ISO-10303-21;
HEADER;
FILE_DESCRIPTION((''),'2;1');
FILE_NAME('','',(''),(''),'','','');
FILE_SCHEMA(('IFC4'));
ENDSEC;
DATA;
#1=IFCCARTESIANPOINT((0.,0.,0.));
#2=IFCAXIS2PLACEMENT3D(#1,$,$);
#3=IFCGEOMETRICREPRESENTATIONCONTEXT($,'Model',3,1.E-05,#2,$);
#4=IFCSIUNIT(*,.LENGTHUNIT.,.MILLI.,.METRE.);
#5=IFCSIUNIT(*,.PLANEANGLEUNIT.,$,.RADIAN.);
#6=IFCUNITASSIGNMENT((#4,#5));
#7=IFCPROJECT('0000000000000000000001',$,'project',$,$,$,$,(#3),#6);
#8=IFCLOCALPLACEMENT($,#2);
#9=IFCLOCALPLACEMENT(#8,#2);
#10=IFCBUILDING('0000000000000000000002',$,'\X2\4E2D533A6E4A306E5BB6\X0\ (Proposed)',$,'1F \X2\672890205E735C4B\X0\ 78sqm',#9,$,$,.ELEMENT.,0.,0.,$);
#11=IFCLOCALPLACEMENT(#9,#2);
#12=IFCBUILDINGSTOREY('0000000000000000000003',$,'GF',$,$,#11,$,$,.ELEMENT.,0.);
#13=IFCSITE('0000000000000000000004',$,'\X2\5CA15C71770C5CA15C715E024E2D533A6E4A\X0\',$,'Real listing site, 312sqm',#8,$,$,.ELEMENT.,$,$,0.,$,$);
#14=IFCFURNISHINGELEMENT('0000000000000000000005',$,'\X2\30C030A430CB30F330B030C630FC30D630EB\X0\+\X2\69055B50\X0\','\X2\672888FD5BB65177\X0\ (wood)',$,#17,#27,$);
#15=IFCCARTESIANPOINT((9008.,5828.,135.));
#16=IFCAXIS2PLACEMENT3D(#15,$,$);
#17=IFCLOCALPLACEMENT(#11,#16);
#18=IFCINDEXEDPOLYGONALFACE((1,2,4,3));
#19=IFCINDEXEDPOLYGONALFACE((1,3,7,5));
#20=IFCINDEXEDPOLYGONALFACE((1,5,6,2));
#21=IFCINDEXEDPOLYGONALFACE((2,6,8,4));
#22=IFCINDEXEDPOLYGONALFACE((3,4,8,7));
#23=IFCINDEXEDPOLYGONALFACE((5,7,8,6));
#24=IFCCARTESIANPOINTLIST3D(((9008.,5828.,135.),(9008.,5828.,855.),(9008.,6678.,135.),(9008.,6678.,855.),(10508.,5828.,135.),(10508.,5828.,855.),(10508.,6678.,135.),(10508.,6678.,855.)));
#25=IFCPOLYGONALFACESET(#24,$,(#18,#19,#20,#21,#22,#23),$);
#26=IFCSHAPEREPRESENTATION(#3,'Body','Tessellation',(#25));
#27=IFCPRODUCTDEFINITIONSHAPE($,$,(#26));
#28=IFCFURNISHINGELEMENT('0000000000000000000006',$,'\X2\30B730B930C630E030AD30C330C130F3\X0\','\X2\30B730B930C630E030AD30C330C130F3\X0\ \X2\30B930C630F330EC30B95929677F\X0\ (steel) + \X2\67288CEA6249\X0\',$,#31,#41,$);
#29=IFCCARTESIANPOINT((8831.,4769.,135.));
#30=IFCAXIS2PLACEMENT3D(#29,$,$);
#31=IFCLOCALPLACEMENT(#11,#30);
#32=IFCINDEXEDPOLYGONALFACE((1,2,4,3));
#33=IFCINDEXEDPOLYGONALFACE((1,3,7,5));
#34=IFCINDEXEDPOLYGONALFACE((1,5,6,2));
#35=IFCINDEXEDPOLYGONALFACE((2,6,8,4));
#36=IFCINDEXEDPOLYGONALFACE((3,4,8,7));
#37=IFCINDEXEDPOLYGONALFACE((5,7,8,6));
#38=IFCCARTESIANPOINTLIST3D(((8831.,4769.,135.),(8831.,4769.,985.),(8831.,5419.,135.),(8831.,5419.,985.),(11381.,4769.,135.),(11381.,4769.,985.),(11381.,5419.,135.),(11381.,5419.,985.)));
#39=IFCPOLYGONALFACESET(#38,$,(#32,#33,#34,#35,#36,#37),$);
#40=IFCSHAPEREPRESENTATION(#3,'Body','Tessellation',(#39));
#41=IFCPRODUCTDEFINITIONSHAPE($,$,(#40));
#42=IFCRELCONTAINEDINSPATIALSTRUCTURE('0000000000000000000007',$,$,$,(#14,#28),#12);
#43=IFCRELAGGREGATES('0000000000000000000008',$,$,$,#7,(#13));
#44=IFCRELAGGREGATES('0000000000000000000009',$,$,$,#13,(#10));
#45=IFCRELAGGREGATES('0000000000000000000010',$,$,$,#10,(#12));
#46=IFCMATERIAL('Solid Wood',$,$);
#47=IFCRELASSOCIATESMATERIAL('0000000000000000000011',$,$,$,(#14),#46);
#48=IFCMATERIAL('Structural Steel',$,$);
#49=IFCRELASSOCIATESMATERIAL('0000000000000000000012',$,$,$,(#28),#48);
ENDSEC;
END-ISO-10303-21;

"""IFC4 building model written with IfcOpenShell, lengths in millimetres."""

from ifc_helpers import new_model, si_unit, frame, frame_2d, origin, place, context, project, spatial, rectangle, extrude, material, element, save


model = new_model("IFC4")

# Units and contexts
model_context = context("Model", 3, precision=1e-05, world=origin())
ifc_project = project(units=[si_unit("LENGTHUNIT", "METRE", prefix="MILLI"), si_unit("PLANEANGLEUNIT", "RADIAN")], contexts=[model_context])

# Site, building, storey
site_placement = place(None, origin())
site = spatial("IfcSite", under=ifc_project, at=site_placement, Name="岡山県岡山市中区湊", ObjectType="Real listing site, 312sqm", CompositionType="ELEMENT", RefElevation=0.0)
building_placement = place(site_placement, origin())
building = spatial("IfcBuilding", under=site, at=building_placement, Name="中区湊の家 (Proposed)", ObjectType="1F 木造平屋 78sqm", CompositionType="ELEMENT", ElevationOfRefHeight=0.0, ElevationOfTerrain=0.0)
storey_placement = place(building_placement, origin())
storey = spatial("IfcBuildingStorey", under=building, at=storey_placement, Name="GF", CompositionType="ELEMENT", Elevation=0.0)

# Shared definitions
ifc_material_1 = material(Name="Solid Wood")

# Shared definitions
ifc_material_2 = material(Name="Structural Steel")

# Furnishing elements
furnishing_1_placement = place(storey_placement, frame((9008.0, 5828.0, 135.0)))
element("IfcFurnishingElement", 1, at=furnishing_1_placement, inside=storey, material=ifc_material_1, Name="ダイニングテーブル+椅子", Description="木製家具 (wood)", context=model_context, shape_type="SweptSolid", body=[
    extrude(rectangle(XDim=1500.0, YDim=850.0, at=frame_2d((750.0, 425.0))), frame((9008.0, 5828.0, 135.0)), (0.0, 0.0, 1.0), 720.0),
])
furnishing_2_placement = place(storey_placement, frame((8831.0, 4769.0, 135.0)))
element("IfcFurnishingElement", 2, at=furnishing_2_placement, inside=storey, material=ifc_material_2, Name="システムキッチン", Description="システムキッチン ステンレス天板 (steel) + 木質扉", context=model_context, shape_type="SweptSolid", body=[
    extrude(rectangle(XDim=2550.0, YDim=650.0, at=frame_2d((1275.0, 325.0))), frame((8831.0, 4769.0, 135.0)), (0.0, 0.0, 1.0), 850.0),
])

save(model, "model.ifc")
